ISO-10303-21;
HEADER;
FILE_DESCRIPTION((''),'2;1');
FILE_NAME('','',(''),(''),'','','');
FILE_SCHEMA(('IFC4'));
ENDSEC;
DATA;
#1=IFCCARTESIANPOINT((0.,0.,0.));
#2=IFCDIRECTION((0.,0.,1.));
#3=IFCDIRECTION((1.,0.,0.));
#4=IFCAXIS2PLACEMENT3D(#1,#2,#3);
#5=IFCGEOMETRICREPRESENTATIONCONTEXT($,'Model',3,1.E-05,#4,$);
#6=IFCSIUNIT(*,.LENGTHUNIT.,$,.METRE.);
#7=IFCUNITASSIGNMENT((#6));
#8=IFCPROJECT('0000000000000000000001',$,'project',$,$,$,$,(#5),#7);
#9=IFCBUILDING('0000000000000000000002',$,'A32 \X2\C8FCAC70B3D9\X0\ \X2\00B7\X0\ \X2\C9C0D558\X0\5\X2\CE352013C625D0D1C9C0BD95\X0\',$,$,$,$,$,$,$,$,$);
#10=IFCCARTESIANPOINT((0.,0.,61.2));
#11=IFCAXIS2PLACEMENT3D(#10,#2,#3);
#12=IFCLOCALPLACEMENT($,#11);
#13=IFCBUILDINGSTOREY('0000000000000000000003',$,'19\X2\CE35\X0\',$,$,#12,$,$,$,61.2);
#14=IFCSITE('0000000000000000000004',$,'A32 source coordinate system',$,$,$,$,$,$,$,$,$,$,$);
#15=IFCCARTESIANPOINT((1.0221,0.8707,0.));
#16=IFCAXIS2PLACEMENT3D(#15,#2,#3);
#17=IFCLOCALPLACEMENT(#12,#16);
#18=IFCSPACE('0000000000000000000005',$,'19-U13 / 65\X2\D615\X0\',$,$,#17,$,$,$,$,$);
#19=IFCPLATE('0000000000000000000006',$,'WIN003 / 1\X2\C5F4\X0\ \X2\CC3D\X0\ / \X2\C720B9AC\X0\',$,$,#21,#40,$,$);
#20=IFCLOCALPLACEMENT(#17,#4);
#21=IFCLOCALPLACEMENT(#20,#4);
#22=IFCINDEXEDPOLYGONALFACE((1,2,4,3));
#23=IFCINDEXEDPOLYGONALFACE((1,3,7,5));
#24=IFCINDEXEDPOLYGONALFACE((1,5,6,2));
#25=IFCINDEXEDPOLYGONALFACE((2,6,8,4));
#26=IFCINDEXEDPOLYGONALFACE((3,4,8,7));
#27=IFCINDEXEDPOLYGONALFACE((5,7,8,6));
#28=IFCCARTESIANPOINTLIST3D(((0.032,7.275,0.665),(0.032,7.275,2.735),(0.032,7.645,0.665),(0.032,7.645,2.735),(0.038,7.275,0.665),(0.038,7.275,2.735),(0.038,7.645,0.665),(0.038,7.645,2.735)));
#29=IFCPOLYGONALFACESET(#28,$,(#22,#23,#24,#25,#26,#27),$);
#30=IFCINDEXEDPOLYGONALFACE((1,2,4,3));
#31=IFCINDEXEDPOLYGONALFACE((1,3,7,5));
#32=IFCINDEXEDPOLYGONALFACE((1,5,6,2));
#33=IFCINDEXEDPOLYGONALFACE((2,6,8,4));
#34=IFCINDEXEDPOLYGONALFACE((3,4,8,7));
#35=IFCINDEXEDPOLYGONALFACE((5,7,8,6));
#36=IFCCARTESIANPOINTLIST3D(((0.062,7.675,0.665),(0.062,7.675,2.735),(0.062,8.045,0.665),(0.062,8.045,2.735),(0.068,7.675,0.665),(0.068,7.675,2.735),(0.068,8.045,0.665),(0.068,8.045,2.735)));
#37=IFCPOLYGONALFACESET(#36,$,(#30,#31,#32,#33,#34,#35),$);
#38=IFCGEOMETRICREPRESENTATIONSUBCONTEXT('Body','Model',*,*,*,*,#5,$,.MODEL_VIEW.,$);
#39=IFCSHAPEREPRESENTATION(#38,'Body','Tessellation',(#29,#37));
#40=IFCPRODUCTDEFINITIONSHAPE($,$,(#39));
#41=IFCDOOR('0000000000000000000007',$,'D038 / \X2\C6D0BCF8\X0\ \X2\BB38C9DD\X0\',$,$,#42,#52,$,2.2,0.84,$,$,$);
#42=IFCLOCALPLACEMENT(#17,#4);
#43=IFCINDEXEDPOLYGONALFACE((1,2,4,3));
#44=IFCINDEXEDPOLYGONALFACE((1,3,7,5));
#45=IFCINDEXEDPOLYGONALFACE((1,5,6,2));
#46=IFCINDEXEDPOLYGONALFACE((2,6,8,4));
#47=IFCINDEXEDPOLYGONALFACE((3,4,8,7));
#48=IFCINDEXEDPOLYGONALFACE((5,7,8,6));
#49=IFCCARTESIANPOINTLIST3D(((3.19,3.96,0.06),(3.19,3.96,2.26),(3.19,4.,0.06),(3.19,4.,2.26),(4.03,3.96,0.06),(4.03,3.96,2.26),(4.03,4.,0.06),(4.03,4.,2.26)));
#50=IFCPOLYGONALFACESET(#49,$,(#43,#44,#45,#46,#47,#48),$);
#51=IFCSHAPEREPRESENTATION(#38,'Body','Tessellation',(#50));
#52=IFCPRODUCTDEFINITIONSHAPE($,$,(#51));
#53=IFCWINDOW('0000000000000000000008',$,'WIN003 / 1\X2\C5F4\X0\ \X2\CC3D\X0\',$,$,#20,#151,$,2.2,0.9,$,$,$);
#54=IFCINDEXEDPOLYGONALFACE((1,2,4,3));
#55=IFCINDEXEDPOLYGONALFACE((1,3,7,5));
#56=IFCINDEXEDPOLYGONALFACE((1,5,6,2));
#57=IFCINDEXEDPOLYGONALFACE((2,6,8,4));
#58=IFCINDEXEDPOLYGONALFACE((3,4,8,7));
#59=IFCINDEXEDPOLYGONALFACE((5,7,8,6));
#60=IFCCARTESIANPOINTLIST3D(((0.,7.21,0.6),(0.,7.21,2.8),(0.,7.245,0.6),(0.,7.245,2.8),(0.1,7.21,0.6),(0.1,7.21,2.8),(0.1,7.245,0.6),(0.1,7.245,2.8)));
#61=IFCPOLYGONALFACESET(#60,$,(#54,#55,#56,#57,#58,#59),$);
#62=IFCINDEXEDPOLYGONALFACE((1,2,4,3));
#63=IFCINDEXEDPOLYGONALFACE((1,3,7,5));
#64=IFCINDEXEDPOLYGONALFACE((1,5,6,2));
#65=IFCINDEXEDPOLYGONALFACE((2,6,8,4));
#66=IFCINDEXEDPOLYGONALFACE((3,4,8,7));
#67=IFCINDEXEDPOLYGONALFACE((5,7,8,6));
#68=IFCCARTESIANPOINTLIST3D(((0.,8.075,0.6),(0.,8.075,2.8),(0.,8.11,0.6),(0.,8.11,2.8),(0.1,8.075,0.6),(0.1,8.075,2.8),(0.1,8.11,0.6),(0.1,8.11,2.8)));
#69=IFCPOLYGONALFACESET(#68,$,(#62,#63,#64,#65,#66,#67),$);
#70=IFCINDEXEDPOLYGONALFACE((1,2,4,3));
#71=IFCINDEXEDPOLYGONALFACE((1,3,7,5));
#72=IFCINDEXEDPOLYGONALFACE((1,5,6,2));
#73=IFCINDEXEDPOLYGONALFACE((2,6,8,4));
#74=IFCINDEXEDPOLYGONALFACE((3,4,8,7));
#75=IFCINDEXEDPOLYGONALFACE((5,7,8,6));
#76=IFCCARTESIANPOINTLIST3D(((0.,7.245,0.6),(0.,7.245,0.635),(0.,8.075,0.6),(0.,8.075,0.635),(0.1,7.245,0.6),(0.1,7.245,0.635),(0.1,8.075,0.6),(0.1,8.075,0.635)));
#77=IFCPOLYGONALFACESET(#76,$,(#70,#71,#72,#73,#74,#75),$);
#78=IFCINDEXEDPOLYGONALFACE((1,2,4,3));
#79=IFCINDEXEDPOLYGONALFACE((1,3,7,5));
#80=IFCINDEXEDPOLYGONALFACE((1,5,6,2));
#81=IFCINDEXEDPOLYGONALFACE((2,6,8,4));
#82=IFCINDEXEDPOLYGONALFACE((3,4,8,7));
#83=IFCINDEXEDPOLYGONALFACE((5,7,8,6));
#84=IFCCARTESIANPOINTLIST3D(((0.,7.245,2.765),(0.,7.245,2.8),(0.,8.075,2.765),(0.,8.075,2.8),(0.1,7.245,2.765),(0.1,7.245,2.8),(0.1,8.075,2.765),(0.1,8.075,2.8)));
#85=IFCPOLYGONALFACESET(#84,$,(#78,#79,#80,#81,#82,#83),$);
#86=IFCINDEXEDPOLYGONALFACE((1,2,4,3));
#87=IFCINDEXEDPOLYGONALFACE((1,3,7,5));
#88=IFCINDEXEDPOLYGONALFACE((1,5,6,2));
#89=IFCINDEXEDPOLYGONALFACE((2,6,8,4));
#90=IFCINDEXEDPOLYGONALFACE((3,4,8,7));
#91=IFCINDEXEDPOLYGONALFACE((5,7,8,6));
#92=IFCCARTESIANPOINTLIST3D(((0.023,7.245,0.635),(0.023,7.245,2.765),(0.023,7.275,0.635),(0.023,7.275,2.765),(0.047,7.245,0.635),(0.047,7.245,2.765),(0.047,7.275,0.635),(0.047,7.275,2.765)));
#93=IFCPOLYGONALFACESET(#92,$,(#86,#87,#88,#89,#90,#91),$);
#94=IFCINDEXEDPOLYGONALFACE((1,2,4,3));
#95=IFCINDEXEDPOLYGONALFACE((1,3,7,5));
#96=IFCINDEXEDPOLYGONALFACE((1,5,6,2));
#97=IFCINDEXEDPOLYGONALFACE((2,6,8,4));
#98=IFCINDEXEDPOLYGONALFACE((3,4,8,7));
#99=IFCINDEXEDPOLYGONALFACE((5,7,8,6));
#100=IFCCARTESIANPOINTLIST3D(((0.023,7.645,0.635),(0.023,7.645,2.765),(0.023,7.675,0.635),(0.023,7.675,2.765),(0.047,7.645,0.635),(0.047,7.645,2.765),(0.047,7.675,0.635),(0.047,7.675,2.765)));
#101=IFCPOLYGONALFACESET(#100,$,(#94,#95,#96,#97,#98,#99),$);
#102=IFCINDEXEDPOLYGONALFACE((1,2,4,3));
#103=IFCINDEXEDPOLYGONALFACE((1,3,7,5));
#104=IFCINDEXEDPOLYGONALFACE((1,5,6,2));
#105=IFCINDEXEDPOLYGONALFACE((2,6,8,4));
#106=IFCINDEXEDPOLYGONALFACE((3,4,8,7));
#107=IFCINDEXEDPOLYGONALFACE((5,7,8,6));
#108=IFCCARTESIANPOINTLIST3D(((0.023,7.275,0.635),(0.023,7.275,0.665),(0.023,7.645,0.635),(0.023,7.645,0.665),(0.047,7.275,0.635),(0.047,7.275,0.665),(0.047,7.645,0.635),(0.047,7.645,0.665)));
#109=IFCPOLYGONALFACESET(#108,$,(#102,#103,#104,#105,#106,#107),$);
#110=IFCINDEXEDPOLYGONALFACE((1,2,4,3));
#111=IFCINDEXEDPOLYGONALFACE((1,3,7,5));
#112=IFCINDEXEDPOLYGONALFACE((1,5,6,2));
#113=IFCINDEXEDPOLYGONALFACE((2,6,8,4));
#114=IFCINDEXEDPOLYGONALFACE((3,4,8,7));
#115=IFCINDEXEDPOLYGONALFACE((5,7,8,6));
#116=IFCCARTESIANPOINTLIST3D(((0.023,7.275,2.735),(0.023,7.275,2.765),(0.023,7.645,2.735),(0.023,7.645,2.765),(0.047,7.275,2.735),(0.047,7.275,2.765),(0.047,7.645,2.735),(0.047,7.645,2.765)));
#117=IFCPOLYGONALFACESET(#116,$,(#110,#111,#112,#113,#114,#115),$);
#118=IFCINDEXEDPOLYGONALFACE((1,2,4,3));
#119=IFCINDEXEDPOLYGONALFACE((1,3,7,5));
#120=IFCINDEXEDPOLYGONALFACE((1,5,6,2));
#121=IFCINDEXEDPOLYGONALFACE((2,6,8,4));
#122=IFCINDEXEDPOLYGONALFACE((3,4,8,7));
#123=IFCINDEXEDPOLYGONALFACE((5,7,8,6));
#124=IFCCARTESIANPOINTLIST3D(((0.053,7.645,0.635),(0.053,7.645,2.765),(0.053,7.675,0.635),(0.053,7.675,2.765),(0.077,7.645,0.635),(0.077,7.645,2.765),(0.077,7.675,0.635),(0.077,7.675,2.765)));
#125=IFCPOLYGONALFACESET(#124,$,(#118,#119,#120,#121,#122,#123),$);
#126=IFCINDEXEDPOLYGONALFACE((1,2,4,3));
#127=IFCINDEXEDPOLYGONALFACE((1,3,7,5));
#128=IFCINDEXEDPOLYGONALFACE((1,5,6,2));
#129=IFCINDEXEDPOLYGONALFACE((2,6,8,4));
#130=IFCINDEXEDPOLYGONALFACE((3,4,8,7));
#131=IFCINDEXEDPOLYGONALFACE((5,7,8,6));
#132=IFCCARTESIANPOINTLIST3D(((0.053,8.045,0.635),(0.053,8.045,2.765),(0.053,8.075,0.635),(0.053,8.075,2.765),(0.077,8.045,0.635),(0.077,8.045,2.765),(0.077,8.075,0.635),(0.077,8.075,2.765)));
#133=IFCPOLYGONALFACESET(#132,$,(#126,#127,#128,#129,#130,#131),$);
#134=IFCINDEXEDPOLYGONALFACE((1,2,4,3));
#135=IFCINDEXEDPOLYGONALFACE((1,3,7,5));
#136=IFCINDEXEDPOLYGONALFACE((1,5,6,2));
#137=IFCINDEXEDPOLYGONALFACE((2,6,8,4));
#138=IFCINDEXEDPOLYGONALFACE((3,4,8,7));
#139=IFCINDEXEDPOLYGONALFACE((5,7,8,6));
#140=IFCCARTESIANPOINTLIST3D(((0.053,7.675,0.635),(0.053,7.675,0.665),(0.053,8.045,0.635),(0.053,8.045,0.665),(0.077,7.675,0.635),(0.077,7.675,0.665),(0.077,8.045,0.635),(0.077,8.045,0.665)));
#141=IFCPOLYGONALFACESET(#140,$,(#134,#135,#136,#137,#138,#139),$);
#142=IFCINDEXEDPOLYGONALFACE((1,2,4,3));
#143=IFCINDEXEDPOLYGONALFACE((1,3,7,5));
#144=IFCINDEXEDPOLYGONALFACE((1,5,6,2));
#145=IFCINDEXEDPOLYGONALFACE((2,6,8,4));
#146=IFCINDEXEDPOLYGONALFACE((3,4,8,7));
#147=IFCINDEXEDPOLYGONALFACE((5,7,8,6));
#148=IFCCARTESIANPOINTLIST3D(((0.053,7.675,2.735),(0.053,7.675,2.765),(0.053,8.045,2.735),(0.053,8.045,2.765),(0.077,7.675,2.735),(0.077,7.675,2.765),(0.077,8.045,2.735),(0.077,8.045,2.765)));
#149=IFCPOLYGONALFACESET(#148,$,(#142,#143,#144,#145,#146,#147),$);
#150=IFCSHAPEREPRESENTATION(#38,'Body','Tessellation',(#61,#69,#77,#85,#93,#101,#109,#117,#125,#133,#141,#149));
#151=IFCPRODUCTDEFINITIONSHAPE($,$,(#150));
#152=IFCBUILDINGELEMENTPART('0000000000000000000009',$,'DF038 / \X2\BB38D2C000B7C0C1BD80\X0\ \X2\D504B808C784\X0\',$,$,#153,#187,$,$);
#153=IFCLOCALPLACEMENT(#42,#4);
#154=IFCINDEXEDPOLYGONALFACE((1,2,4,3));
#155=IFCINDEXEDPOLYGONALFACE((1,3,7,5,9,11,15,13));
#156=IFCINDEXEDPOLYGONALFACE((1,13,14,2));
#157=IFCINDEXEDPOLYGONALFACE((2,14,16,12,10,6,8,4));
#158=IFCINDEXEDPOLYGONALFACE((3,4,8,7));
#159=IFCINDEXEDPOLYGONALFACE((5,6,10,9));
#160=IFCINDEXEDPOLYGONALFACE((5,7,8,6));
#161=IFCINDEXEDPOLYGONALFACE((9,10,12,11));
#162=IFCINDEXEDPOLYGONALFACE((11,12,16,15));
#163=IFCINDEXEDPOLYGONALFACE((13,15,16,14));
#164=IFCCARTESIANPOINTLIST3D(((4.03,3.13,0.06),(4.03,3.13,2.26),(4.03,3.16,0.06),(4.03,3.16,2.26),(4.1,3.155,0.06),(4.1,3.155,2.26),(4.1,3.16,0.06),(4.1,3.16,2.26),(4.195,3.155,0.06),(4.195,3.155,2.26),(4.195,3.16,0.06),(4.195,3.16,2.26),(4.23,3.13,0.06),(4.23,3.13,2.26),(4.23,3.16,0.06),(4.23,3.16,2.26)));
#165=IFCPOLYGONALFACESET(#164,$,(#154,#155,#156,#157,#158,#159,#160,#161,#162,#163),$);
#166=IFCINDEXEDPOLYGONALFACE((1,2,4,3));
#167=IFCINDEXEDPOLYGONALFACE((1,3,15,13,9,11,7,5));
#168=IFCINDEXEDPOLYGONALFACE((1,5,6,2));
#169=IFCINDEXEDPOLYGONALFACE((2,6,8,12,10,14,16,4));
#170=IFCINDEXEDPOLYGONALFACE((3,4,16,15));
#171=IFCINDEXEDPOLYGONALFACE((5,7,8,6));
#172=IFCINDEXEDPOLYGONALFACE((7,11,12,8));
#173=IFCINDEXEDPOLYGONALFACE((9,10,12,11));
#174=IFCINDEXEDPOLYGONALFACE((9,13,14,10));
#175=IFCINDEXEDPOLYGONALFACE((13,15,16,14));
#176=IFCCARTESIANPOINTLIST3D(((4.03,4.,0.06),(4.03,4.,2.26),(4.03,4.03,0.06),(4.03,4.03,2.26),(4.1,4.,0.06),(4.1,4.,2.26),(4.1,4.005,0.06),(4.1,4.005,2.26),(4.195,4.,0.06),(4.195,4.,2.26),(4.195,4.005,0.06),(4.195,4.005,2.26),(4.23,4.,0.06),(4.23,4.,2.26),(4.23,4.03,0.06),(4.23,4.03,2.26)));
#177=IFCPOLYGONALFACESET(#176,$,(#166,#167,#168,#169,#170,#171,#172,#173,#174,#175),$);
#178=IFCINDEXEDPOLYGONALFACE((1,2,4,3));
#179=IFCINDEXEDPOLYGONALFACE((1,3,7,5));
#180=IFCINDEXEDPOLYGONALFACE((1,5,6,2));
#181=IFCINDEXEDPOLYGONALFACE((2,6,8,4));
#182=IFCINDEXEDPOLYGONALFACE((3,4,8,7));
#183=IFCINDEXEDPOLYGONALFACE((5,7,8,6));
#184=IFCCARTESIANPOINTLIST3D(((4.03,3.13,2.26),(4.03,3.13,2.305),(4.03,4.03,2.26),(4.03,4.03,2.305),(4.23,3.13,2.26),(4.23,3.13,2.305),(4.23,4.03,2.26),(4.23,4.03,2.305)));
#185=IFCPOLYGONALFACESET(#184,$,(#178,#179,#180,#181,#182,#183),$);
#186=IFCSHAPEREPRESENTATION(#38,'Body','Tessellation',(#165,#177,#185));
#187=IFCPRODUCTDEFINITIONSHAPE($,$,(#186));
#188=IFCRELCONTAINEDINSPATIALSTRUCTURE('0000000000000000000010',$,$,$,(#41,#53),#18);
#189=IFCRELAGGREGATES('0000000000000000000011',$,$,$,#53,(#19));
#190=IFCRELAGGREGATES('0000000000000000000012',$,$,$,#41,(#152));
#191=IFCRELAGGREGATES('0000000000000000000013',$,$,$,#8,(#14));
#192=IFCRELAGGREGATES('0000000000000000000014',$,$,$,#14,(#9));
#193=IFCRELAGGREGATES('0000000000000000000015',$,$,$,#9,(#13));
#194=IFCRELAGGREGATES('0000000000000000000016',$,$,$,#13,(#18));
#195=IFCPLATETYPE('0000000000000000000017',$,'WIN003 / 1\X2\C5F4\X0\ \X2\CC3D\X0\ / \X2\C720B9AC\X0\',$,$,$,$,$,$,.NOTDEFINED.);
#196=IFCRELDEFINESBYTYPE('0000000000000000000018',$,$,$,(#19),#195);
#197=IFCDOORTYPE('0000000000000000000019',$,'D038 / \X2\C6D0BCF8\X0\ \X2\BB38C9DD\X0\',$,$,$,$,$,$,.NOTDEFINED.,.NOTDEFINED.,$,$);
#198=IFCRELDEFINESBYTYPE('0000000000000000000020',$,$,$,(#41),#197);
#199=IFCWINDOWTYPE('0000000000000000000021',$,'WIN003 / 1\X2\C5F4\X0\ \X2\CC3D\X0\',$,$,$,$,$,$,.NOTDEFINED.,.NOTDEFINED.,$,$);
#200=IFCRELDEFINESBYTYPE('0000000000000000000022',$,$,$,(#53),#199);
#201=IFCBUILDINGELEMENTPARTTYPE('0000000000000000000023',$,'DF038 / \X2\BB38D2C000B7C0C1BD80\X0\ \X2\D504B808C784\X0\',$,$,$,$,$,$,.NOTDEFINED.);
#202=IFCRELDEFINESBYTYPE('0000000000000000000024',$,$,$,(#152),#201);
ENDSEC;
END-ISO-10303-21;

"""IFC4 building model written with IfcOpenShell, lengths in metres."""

from ifc_helpers import new_model, si_unit, frame, origin, origin_with_axes, place, context, subcontext, project, spatial, polyline, outline, extrude, source, transform, mapped, type_object, type_shapes, element, aggregate, save


model = new_model("IFC4")

# Units and contexts
model_context = context("Model", 3, precision=1e-05, world=origin_with_axes())
body_context = subcontext(model_context, "Body", "Model", "MODEL_VIEW")
ifc_project = project(units=[si_unit("LENGTHUNIT", "METRE")], contexts=[model_context])

# Plate
storey_placement = place(None, frame((0.0, 0.0, 61.2), z_axis=(0.0, 0.0, 1.0), x_axis=(1.0, 0.0, 0.0)))
space_placement = place(storey_placement, frame((1.0221, 0.8707, 0.0), z_axis=(0.0, 0.0, 1.0), x_axis=(1.0, 0.0, 0.0)))
plate_type_1 = type_object("IfcPlateType", Name="WIN003 / 1열 창 / 유리", PredefinedType="NOTDEFINED")
shared_shape_1 = source(origin(), body_context, "Body", "SweptSolid", [
    extrude(outline(polyline([(0.032, 7.275), (0.032, 7.645), (0.038, 7.645), (0.038, 7.275), (0.032, 7.275)])), frame((0.0, 0.0, 0.665)), (0.0, 0.0, 1.0), 2.07),
    extrude(outline(polyline([(0.062, 7.675), (0.062, 8.045), (0.068, 8.045), (0.068, 7.675), (0.062, 7.675)])), frame((0.0, 0.0, 0.665)), (0.0, 0.0, 1.0), 2.07),
])
type_shapes(plate_type_1, [shared_shape_1])
window_1_placement = place(space_placement, origin_with_axes())
plate_1_placement = place(window_1_placement, origin_with_axes())
plate_1 = element("IfcPlate", 1, at=plate_1_placement, type_object=plate_type_1, Name="WIN003 / 1열 창 / 유리", context=body_context, shape_type="MappedRepresentation", body=[
    mapped(shared_shape_1, transform((0.0, 0.0, 0.0), scale=1.0)),
])

# Site, building, storey, space
site = spatial("IfcSite", under=ifc_project, Name="A32 source coordinate system")
building = spatial("IfcBuilding", under=site, Name="A32 주거동 · 지하5층–옥탑지붕")
storey = spatial("IfcBuildingStorey", under=building, at=storey_placement, Name="19층", Elevation=61.2)
space = spatial("IfcSpace", under=storey, at=space_placement, Name="19-U13 / 65형")

# Door
door_type_1 = type_object("IfcDoorType", Name="D038 / 원본 문짝", OperationType="NOTDEFINED", PredefinedType="NOTDEFINED")
shared_shape_2 = source(origin(), body_context, "Body", "SweptSolid", [
    extrude(outline(polyline([(3.19, 3.96), (3.19, 4.0), (4.03, 4.0), (4.03, 3.96), (3.19, 3.96)])), frame((0.0, 0.0, 0.06)), (0.0, 0.0, 1.0), 2.2),
])
type_shapes(door_type_1, [shared_shape_2])
door_1_placement = place(space_placement, origin_with_axes())
door_1 = element("IfcDoor", 2, at=door_1_placement, inside=space, type_object=door_type_1, Name="D038 / 원본 문짝", OverallHeight=2.2, OverallWidth=0.84, context=body_context, shape_type="MappedRepresentation", body=[
    mapped(shared_shape_2, transform((0.0, 0.0, 0.0), scale=1.0)),
])

# Window
window_type_1 = type_object("IfcWindowType", Name="WIN003 / 1열 창", PartitioningType="NOTDEFINED", PredefinedType="NOTDEFINED")
shared_shape_3 = source(origin(), body_context, "Body", "SweptSolid", [
    extrude(outline(polyline([(0.0, 7.21), (0.0, 7.245), (0.1, 7.245), (0.1, 7.21), (0.0, 7.21)])), frame((0.0, 0.0, 0.6)), (0.0, 0.0, 1.0), 2.2),
    extrude(outline(polyline([(0.0, 8.075), (0.0, 8.11), (0.1, 8.11), (0.1, 8.075), (0.0, 8.075)])), frame((0.0, 0.0, 0.6)), (0.0, 0.0, 1.0), 2.2),
    extrude(outline(polyline([(0.0, 7.245), (0.0, 8.075), (0.1, 8.075), (0.1, 7.245), (0.0, 7.245)])), frame((0.0, 0.0, 0.6)), (0.0, 0.0, 1.0), 0.035),
    extrude(outline(polyline([(0.0, 7.245), (0.0, 8.075), (0.1, 8.075), (0.1, 7.245), (0.0, 7.245)])), frame((0.0, 0.0, 2.765)), (0.0, 0.0, 1.0), 0.035),
    extrude(outline(polyline([(0.023, 7.245), (0.023, 7.275), (0.047, 7.275), (0.047, 7.245), (0.023, 7.245)])), frame((0.0, 0.0, 0.635)), (0.0, 0.0, 1.0), 2.13),
    extrude(outline(polyline([(0.023, 7.645), (0.023, 7.675), (0.047, 7.675), (0.047, 7.645), (0.023, 7.645)])), frame((0.0, 0.0, 0.635)), (0.0, 0.0, 1.0), 2.13),
    extrude(outline(polyline([(0.023, 7.275), (0.023, 7.645), (0.047, 7.645), (0.047, 7.275), (0.023, 7.275)])), frame((0.0, 0.0, 0.635)), (0.0, 0.0, 1.0), 0.03),
    extrude(outline(polyline([(0.023, 7.275), (0.023, 7.645), (0.047, 7.645), (0.047, 7.275), (0.023, 7.275)])), frame((0.0, 0.0, 2.735)), (0.0, 0.0, 1.0), 0.03),
    extrude(outline(polyline([(0.053, 7.645), (0.053, 7.675), (0.077, 7.675), (0.077, 7.645), (0.053, 7.645)])), frame((0.0, 0.0, 0.635)), (0.0, 0.0, 1.0), 2.13),
    extrude(outline(polyline([(0.053, 8.045), (0.053, 8.075), (0.077, 8.075), (0.077, 8.045), (0.053, 8.045)])), frame((0.0, 0.0, 0.635)), (0.0, 0.0, 1.0), 2.13),
    extrude(outline(polyline([(0.053, 7.675), (0.053, 8.045), (0.077, 8.045), (0.077, 7.675), (0.053, 7.675)])), frame((0.0, 0.0, 0.635)), (0.0, 0.0, 1.0), 0.03),
    extrude(outline(polyline([(0.053, 7.675), (0.053, 8.045), (0.077, 8.045), (0.077, 7.675), (0.053, 7.675)])), frame((0.0, 0.0, 2.735)), (0.0, 0.0, 1.0), 0.03),
])
type_shapes(window_type_1, [shared_shape_3])
window_1 = element("IfcWindow", 3, at=window_1_placement, inside=space, type_object=window_type_1, Name="WIN003 / 1열 창", OverallHeight=2.2, OverallWidth=0.9, context=body_context, shape_type="MappedRepresentation", body=[
    mapped(shared_shape_3, transform((0.0, 0.0, 0.0), scale=1.0)),
])
aggregate(window_1, [plate_1])

# Building element part
building_element_part_type_1 = type_object("IfcBuildingElementPartType", Name="DF038 / 문틀·상부 프레임", PredefinedType="NOTDEFINED")
shared_shape_4 = source(origin(), body_context, "Body", "SweptSolid", [
    extrude(outline(polyline([(4.03, 3.16), (4.1, 3.16), (4.1, 3.155), (4.195, 3.155), (4.195, 3.16), (4.23, 3.16), (4.23, 3.13), (4.03, 3.13), (4.03, 3.16)])), frame((0.0, 0.0, 0.06)), (0.0, 0.0, 1.0), 2.2),
    extrude(outline(polyline([(4.23, 4.03), (4.23, 4.0), (4.195, 4.0), (4.195, 4.005), (4.1, 4.005), (4.1, 4.0), (4.03, 4.0), (4.03, 4.03), (4.23, 4.03)])), frame((0.0, 0.0, 0.06)), (0.0, 0.0, 1.0), 2.2),
    extrude(outline(polyline([(4.03, 3.13), (4.03, 4.03), (4.23, 4.03), (4.23, 3.13), (4.03, 3.13)])), frame((0.0, 0.0, 2.26)), (0.0, 0.0, 1.0), 0.045),
])
type_shapes(building_element_part_type_1, [shared_shape_4])
building_element_part_1_placement = place(door_1_placement, origin_with_axes())
building_element_part_1 = element("IfcBuildingElementPart", 4, at=building_element_part_1_placement, type_object=building_element_part_type_1, Name="DF038 / 문틀·상부 프레임", context=body_context, shape_type="MappedRepresentation", body=[
    mapped(shared_shape_4, transform((0.0, 0.0, 0.0), scale=1.0)),
])
aggregate(door_1, [building_element_part_1])

save(model, "model.ifc")
